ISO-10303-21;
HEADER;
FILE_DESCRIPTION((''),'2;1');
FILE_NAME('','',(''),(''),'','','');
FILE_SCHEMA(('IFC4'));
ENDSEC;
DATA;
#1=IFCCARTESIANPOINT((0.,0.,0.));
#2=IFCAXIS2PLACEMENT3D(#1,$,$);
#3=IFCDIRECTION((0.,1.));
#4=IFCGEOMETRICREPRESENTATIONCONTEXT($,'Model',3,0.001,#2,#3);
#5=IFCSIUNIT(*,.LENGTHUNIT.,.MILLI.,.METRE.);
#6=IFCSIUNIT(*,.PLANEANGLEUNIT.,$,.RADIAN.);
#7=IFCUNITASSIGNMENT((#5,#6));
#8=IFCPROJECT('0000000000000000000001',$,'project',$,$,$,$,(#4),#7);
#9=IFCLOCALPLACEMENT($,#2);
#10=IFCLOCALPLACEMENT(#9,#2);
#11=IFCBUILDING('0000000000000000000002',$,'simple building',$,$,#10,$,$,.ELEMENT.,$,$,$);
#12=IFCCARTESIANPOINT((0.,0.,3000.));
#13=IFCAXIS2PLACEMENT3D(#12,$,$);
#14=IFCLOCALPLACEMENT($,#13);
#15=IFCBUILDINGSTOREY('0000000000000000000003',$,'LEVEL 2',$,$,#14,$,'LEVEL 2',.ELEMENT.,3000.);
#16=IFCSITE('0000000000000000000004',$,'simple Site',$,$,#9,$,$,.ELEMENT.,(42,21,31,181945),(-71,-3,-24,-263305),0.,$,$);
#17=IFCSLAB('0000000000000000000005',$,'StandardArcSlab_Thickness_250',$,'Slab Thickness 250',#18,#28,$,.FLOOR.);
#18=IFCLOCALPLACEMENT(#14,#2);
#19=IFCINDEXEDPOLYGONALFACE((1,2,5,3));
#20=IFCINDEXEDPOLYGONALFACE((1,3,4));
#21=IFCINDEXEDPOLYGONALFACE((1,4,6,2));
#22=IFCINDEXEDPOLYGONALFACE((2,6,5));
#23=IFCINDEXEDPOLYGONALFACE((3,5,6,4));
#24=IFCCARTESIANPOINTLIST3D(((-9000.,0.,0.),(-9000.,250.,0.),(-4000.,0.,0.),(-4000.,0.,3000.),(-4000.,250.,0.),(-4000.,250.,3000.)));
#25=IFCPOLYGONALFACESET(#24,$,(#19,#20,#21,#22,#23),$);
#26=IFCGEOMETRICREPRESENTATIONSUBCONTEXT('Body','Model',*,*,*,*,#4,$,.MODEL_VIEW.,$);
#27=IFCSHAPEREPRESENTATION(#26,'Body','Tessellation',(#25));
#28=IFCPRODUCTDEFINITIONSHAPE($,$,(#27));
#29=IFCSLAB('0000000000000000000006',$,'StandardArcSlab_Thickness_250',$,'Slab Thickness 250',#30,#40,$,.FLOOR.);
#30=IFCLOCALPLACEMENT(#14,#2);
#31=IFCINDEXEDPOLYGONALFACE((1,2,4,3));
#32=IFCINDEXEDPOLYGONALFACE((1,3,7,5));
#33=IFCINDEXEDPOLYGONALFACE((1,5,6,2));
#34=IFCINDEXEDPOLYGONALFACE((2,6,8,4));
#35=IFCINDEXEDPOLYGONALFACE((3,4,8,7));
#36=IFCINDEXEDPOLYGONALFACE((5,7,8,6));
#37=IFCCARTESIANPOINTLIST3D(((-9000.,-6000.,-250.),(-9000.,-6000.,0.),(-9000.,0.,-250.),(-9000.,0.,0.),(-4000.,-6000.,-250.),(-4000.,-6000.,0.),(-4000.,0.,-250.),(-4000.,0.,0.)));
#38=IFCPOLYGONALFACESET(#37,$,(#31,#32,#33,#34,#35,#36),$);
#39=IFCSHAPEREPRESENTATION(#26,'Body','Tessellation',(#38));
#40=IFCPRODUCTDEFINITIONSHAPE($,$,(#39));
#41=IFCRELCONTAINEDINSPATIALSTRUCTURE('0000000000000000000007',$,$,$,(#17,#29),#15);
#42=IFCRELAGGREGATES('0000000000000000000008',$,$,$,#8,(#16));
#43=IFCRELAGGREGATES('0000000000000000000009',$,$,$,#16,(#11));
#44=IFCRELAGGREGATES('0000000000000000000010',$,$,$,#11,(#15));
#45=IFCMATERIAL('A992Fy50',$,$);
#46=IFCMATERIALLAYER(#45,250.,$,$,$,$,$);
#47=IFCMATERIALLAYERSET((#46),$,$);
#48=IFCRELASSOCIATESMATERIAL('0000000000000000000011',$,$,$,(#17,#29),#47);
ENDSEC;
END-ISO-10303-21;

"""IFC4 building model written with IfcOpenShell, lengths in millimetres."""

from ifc_helpers import new_model, si_unit, direction, frame, origin, origin_with_axes, place, context, subcontext, project, spatial, polyline, outline, extrude, material, layer, layer_set, layer_usage, element, save


model = new_model("IFC4")

# Units and contexts
model_context = context("Model", 3, precision=0.001, world=origin(), true_north=direction((0.0, 1.0)))
body_context = subcontext(model_context, "Body", "Model", "MODEL_VIEW")
ifc_project = project(units=[si_unit("LENGTHUNIT", "METRE", prefix="MILLI"), si_unit("PLANEANGLEUNIT", "RADIAN")], contexts=[model_context])

# Site, building, storey
site_placement = place(None, origin())
site = spatial("IfcSite", under=ifc_project, at=site_placement, Name="simple Site", CompositionType="ELEMENT", RefLatitude=(42, 21, 31, 181945), RefLongitude=(-71, -3, -24, -263305), RefElevation=0.0)
building_placement = place(site_placement, origin())
building = spatial("IfcBuilding", under=site, at=building_placement, Name="simple building", CompositionType="ELEMENT")
storey_placement = place(None, frame((0.0, 0.0, 3000.0)))
storey = spatial("IfcBuildingStorey", under=building, at=storey_placement, Name="LEVEL 2", LongName="LEVEL 2", CompositionType="ELEMENT", Elevation=3000.0)

# Slabs
ifc_material_1 = material(Name="A992Fy50")
ifc_layer = layer(ifc_material_1, 250.0)
ifc_layer_set = layer_set([ifc_layer])
ifc_layer_usage = layer_usage(ifc_layer_set, "AXIS3", "POSITIVE", -250.0)
slab_1_placement = place(None, frame((-9000.0, 250.0, 3000.0), z_axis=(0.0, -1.0, 0.0), x_axis=(1.0, 0.0, 0.0)))
element("IfcSlab", 1, at=slab_1_placement, inside=storey, material=ifc_layer_usage, Name="StandardArcSlab_Thickness_250", ObjectType="Slab Thickness 250", PredefinedType="FLOOR", context=body_context, shape_type="SweptSolid", body=[
    extrude(outline(polyline([(0.0, 0.0), (5000.0, 0.0), (5000.0, 3000.0), (0.0, 0.0)])), origin_with_axes(), (0.0, 0.0, 1.0), 250.0),
])
slab_2_placement = place(None, frame((-9000.0, 0.0, 2750.0), z_axis=(0.0, 0.0, 1.0), x_axis=(0.0, -1.0, 0.0)))
element("IfcSlab", 2, at=slab_2_placement, inside=storey, material=ifc_layer_usage, Name="StandardArcSlab_Thickness_250", ObjectType="Slab Thickness 250", PredefinedType="FLOOR", context=body_context, shape_type="SweptSolid", body=[
    extrude(outline(polyline([(0.0, 0.0), (6000.0, 0.0), (6000.0, 5000.0), (0.0, 5000.0), (0.0, 0.0)])), origin_with_axes(), (0.0, 0.0, 1.0), 250.0),
])

save(model, "model.ifc")
